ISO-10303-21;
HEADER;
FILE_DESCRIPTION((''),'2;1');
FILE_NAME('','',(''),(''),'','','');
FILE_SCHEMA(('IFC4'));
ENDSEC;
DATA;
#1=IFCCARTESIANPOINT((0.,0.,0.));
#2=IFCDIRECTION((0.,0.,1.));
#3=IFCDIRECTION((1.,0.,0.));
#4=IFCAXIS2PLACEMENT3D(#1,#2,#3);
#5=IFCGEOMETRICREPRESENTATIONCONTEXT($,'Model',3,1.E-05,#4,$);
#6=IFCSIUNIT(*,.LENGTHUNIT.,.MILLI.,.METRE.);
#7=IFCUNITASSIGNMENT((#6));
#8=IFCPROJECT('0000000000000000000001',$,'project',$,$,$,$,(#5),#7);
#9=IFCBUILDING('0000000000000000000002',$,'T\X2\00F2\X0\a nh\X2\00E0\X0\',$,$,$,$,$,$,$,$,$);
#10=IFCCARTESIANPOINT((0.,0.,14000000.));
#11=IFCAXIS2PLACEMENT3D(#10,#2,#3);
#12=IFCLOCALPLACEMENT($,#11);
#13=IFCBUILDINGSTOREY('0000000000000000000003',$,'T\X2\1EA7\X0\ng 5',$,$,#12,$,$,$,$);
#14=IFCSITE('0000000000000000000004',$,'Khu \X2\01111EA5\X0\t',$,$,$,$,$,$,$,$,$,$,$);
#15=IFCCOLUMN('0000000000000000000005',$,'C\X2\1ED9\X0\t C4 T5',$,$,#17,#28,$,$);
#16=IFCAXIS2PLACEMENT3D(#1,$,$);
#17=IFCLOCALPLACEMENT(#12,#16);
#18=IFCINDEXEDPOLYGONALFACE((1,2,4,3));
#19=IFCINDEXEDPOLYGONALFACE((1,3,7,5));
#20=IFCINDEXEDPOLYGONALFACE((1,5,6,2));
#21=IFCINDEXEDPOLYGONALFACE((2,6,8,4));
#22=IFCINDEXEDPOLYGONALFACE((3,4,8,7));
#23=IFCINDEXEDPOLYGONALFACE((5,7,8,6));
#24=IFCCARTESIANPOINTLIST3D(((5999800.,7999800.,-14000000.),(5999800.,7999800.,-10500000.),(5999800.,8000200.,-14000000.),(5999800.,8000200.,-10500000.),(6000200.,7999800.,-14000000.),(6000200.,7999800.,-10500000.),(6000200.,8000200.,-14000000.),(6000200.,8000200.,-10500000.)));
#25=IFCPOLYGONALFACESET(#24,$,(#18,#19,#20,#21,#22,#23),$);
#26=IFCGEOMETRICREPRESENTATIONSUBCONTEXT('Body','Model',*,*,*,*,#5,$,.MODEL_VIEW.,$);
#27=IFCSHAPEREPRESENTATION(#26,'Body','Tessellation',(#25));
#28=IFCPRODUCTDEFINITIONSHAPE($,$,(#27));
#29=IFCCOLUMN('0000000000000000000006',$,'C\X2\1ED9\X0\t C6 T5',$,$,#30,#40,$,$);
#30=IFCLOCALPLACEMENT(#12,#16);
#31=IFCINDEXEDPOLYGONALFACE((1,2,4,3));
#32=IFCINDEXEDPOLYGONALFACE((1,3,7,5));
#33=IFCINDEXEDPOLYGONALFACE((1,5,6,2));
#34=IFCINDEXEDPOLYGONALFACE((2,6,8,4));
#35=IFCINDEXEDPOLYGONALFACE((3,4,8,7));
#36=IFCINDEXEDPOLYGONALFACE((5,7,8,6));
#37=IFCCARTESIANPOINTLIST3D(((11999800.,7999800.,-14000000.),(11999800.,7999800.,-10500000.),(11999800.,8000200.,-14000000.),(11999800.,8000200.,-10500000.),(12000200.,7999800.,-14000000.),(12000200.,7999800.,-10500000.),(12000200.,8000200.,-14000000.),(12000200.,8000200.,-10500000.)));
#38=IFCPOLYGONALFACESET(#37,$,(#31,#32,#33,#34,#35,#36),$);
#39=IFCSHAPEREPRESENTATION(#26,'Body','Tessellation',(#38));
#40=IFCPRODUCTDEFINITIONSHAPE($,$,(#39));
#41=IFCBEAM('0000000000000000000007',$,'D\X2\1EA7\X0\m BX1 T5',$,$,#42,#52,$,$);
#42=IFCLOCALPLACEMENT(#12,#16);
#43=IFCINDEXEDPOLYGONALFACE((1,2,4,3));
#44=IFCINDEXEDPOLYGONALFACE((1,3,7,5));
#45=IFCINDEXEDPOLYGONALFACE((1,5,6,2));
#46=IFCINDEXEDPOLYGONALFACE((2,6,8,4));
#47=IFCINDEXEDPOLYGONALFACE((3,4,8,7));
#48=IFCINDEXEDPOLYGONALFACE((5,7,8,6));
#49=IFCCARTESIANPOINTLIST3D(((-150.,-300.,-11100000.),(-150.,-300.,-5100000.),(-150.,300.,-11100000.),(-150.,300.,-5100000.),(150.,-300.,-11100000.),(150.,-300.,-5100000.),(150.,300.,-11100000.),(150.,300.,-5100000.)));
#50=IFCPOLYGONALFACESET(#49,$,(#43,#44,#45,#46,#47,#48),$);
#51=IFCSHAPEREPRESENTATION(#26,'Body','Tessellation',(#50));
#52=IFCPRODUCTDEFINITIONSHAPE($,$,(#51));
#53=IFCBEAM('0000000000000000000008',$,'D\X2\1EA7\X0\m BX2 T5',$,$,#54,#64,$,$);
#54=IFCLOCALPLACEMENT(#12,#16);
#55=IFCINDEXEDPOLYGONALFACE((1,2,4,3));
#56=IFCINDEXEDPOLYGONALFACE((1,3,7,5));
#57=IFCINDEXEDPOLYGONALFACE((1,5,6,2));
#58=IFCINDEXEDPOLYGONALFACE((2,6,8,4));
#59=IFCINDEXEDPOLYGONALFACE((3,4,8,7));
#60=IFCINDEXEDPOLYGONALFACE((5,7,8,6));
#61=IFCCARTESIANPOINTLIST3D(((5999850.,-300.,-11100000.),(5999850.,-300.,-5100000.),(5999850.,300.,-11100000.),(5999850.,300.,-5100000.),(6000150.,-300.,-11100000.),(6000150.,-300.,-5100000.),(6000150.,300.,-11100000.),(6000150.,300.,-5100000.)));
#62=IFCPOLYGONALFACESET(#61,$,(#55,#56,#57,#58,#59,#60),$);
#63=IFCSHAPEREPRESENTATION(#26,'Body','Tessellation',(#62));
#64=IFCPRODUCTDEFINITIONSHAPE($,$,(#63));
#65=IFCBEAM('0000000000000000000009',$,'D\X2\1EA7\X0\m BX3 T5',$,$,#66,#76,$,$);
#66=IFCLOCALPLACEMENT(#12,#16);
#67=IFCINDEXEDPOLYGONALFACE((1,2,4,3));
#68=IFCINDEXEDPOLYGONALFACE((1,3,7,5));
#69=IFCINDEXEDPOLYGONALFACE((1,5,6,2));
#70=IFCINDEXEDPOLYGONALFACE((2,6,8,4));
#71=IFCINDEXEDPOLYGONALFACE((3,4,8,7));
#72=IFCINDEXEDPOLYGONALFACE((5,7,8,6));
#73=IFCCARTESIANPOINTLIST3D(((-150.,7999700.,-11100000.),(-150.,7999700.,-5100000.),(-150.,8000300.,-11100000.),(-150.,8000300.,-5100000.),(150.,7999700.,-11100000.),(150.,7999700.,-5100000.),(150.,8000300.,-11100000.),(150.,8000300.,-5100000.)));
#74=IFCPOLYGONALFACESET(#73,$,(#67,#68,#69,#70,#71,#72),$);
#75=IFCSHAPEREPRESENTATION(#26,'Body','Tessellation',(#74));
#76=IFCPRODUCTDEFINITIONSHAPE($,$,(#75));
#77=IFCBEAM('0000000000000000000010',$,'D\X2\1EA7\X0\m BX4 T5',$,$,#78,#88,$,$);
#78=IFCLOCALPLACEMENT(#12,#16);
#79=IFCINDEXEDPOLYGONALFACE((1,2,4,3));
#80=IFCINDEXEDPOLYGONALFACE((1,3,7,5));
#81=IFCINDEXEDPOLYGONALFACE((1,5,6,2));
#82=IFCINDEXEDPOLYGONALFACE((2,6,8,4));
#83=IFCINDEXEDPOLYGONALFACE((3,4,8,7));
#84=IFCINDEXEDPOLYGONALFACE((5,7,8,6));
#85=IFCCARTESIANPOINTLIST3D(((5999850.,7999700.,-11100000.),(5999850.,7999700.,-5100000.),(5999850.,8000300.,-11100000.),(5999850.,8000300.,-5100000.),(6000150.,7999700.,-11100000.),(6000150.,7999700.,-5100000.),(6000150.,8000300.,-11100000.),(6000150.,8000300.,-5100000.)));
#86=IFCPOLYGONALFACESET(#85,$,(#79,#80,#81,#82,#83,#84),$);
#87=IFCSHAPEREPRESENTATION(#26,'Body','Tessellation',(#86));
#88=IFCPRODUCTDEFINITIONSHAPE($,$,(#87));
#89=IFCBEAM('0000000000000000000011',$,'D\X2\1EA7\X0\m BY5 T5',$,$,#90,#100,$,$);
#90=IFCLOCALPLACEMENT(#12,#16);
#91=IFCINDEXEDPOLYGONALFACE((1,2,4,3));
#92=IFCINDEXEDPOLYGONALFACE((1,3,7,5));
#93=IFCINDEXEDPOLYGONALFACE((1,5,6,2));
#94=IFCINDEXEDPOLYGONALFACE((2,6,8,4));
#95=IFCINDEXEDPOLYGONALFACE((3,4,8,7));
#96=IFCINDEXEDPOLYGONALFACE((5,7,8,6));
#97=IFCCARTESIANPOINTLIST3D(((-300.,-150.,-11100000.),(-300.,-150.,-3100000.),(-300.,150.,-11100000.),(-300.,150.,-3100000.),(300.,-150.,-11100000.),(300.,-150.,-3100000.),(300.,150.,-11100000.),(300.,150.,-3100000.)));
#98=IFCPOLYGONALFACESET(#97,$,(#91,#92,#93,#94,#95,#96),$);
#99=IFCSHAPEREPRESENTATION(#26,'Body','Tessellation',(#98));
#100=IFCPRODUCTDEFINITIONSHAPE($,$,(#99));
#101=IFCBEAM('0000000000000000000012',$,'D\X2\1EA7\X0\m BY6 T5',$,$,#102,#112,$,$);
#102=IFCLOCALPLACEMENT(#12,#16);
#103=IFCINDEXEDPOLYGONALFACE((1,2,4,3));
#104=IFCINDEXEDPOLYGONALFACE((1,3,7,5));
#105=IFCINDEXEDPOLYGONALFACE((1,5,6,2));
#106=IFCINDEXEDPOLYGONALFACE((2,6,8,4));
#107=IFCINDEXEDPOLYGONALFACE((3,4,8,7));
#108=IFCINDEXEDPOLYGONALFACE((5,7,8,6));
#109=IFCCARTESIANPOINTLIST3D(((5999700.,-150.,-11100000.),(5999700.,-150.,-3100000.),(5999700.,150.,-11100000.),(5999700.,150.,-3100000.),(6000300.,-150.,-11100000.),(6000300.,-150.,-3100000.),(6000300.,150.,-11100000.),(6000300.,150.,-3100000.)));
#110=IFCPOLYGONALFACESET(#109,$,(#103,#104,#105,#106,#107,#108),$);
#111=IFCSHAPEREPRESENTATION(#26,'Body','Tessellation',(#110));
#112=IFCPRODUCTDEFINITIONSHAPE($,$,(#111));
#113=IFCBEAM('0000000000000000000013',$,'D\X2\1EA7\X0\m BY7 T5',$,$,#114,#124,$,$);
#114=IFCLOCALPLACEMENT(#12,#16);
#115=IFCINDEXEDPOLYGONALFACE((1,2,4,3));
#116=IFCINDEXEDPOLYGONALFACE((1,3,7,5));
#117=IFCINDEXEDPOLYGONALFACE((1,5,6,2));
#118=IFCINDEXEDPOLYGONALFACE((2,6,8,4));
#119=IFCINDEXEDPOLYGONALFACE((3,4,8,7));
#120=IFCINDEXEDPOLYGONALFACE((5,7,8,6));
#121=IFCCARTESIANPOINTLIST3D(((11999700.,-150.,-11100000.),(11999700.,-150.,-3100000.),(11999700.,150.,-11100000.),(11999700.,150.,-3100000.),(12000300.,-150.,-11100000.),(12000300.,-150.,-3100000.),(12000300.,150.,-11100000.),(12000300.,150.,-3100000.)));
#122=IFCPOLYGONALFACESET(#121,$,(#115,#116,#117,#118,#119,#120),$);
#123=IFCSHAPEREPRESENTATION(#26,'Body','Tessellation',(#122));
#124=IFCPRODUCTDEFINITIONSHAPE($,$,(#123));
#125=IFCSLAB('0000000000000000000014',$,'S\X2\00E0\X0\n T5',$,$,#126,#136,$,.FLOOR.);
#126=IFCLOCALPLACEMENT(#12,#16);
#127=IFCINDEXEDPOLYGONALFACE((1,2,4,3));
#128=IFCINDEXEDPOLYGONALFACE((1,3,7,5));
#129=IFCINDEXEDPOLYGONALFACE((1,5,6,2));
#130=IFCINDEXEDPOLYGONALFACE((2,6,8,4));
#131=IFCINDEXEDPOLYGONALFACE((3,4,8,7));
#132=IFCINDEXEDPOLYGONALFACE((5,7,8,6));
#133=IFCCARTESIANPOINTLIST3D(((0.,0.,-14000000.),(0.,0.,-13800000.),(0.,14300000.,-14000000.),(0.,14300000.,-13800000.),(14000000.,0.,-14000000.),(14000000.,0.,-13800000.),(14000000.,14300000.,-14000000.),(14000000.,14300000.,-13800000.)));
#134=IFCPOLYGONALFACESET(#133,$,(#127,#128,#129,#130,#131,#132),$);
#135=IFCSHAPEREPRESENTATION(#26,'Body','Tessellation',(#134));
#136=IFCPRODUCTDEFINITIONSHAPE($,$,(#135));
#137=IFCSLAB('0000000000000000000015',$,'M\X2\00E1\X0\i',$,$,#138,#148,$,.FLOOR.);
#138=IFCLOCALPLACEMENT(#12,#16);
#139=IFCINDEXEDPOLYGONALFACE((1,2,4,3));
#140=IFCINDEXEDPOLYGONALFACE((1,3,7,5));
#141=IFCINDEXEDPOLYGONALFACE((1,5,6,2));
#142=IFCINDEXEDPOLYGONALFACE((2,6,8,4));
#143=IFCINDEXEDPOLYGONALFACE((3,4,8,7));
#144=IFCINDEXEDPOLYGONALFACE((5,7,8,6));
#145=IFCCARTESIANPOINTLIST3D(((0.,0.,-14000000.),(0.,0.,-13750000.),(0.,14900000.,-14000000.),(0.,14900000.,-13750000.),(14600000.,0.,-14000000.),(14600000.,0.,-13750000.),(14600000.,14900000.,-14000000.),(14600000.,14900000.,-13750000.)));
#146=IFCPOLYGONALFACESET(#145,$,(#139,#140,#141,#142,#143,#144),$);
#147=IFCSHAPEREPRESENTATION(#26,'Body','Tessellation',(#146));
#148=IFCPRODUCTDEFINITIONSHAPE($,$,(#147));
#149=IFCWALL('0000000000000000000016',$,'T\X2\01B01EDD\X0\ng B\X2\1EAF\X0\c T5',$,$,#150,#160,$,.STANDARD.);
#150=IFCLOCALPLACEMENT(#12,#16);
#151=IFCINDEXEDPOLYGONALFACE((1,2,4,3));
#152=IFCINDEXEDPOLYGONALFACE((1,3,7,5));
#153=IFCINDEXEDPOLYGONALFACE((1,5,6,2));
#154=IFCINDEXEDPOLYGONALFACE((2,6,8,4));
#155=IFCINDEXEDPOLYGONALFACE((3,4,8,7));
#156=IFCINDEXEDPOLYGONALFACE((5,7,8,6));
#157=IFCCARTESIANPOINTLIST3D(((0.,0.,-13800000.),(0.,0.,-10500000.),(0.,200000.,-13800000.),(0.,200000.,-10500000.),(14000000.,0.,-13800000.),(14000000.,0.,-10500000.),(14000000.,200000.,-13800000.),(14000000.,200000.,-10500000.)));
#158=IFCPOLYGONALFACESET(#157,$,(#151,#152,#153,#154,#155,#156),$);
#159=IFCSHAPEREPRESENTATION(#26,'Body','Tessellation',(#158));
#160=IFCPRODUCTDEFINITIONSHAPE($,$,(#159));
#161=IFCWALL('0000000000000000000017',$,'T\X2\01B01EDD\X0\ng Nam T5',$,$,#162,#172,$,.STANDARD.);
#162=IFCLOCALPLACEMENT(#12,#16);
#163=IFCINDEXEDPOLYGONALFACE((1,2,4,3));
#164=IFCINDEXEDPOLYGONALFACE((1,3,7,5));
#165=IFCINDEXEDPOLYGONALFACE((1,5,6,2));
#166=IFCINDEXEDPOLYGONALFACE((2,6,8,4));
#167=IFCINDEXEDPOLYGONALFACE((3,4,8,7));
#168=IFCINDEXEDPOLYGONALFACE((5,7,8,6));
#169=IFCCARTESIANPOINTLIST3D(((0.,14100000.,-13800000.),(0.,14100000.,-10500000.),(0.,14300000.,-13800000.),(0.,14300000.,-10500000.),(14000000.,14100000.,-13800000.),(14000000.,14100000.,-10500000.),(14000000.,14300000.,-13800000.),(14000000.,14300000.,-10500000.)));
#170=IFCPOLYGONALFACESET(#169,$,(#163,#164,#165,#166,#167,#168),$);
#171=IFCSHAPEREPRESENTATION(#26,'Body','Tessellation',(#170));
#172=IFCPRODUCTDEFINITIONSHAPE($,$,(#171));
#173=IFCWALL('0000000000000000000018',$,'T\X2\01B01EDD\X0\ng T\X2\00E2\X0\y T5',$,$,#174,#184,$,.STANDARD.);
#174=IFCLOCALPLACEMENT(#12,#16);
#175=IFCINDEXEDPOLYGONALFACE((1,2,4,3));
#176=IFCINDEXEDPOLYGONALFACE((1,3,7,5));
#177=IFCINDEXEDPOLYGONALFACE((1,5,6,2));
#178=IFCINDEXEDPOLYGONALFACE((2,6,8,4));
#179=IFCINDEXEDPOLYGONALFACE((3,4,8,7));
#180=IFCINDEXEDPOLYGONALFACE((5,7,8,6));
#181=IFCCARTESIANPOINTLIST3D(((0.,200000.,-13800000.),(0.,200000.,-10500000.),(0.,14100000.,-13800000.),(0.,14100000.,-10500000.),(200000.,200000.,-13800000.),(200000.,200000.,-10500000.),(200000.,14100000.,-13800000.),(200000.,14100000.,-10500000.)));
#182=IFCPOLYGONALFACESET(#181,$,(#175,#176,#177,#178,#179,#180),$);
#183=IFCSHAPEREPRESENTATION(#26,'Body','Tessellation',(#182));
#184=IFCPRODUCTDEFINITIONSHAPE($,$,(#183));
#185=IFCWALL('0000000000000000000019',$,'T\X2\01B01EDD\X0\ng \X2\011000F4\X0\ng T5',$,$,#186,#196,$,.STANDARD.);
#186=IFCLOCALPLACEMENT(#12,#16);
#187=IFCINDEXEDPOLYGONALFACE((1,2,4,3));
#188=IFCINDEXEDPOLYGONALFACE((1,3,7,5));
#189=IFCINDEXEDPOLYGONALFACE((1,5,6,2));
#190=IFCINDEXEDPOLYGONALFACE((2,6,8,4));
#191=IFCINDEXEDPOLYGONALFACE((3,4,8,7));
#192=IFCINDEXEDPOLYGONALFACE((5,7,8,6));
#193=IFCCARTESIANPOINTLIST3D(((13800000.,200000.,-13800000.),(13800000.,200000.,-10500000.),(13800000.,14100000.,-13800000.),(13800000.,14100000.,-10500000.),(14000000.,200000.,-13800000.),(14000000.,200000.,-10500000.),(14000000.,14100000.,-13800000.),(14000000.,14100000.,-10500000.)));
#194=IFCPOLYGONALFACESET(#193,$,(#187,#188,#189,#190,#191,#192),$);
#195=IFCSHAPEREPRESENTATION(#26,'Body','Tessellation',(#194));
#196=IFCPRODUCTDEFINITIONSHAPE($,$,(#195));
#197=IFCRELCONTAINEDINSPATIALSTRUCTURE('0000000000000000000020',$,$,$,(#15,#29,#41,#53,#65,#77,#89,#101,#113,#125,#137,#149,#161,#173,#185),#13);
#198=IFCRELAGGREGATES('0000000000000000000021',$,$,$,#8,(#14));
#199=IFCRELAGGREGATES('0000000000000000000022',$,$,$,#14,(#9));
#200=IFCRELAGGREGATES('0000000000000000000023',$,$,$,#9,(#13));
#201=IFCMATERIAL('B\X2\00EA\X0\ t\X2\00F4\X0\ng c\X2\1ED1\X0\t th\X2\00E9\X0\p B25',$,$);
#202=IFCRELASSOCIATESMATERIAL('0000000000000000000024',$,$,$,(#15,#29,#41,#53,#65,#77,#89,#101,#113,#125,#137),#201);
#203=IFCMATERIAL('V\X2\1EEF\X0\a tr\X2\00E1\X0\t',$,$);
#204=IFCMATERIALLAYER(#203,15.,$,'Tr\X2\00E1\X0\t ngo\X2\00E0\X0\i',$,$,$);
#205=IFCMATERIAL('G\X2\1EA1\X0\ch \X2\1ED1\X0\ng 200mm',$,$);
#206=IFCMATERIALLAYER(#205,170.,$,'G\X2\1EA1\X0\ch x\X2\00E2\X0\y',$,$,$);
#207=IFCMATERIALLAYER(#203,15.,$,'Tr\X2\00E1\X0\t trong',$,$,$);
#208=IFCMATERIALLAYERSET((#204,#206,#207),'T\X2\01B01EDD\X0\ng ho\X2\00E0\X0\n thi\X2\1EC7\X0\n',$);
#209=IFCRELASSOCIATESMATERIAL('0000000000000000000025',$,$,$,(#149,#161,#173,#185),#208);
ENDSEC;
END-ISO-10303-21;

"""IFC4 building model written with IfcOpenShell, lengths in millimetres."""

from ifc_helpers import new_model, entity, si_unit, frame, origin_with_axes, place, context, subcontext, project, spatial, indexed_curve, outline, extrude, material, layer, layer_set, layer_usage, element, save


model = new_model("IFC4")

# Units and contexts
model_context = context("Model", 3, precision=1e-05, world=origin_with_axes())
body_context = subcontext(model_context, "Body", "Model", "MODEL_VIEW")
ifc_project = project(units=[si_unit("LENGTHUNIT", "METRE", prefix="MILLI")], contexts=[model_context])

# Site, building, storey
site = spatial("IfcSite", under=ifc_project, Name="Khu đất")
building = spatial("IfcBuilding", under=site, Name="Tòa nhà")
storey_placement = place(None, frame((0.0, 0.0, 14000000.0), z_axis=(0.0, 0.0, 1.0), x_axis=(1.0, 0.0, 0.0)))
storey = spatial("IfcBuildingStorey", under=building, at=storey_placement, Name="Tầng 5")

# Columns
ifc_material_1 = material(Name="Bê tông cốt thép B25")
for number, where, z_axis, x_axis, name in (
    (1, (6000000.0, 8000000.0, -14000000.0), (0.0, 0.0, 1.0), (1.0, 0.0, 0.0), "Cột C4 T5"),
    (2, (12000000.0, 8000000.0, -14000000.0), (0.0, 0.0, 1.0), (1.0, 0.0, 0.0), "Cột C6 T5"),
):
    element("IfcColumn", number, at=place(storey_placement, frame(where, z_axis=z_axis, x_axis=x_axis)), inside=storey, material=ifc_material_1, Name=name, context=body_context, shape_type="SweptSolid", body=[
        extrude(entity("IfcRectangleProfileDef", None, None, None, 400.0, 400.0), origin_with_axes(), (0.0, 0.0, 1.0), 3500000.0),
    ])

# Beams
for number, where, z_axis, x_axis, name in (
    (3, (0.0, 0.0, -11100000.0), (0.0, 0.0, 1.0), (1.0, 0.0, 0.0), "Dầm BX1 T5"),
    (4, (6000000.0, 0.0, -11100000.0), (0.0, 0.0, 1.0), (1.0, 0.0, 0.0), "Dầm BX2 T5"),
    (5, (0.0, 8000000.0, -11100000.0), (0.0, 0.0, 1.0), (1.0, 0.0, 0.0), "Dầm BX3 T5"),
    (6, (6000000.0, 8000000.0, -11100000.0), (0.0, 0.0, 1.0), (1.0, 0.0, 0.0), "Dầm BX4 T5"),
):
    element("IfcBeam", number, at=place(storey_placement, frame(where, z_axis=z_axis, x_axis=x_axis)), inside=storey, material=ifc_material_1, Name=name, context=body_context, shape_type="SweptSolid", body=[
        extrude(entity("IfcRectangleProfileDef", None, None, None, 300.0, 600.0), origin_with_axes(), (0.0, 0.0, 1.0), 6000000.0),
    ])
for number, where, z_axis, x_axis, name in (
    (7, (0.0, 0.0, -11100000.0), (0.0, 0.0, 1.0), (0.0, 1.0, 0.0), "Dầm BY5 T5"),
    (8, (6000000.0, 0.0, -11100000.0), (0.0, 0.0, 1.0), (0.0, 1.0, 0.0), "Dầm BY6 T5"),
    (9, (12000000.0, 0.0, -11100000.0), (0.0, 0.0, 1.0), (0.0, 1.0, 0.0), "Dầm BY7 T5"),
):
    element("IfcBeam", number, at=place(storey_placement, frame(where, z_axis=z_axis, x_axis=x_axis)), inside=storey, material=ifc_material_1, Name=name, context=body_context, shape_type="SweptSolid", body=[
        extrude(entity("IfcRectangleProfileDef", None, None, None, 300.0, 600.0), origin_with_axes(), (0.0, 0.0, 1.0), 8000000.0),
    ])

# Slabs
slab_1_placement = place(storey_placement, frame((0.0, 0.0, -14000000.0), z_axis=(0.0, 0.0, 1.0), x_axis=(1.0, 0.0, 0.0)))
element("IfcSlab", 10, at=slab_1_placement, inside=storey, material=ifc_material_1, Name="Sàn T5", PredefinedType="FLOOR", context=body_context, shape_type="SweptSolid", body=[
    extrude(outline(indexed_curve([(0.0, 0.0), (14000000.0, 0.0), (14000000.0, 14300000.0), (0.0, 14300000.0), (0.0, 0.0)])), None, (0.0, 0.0, 1.0), 200000.0),
])
slab_2_placement = place(storey_placement, frame((0.0, 0.0, -14000000.0), z_axis=(0.0, 0.0, 1.0), x_axis=(1.0, 0.0, 0.0)))
element("IfcSlab", 11, at=slab_2_placement, inside=storey, material=ifc_material_1, Name="Mái", PredefinedType="FLOOR", context=body_context, shape_type="SweptSolid", body=[
    extrude(outline(indexed_curve([(0.0, 0.0), (14600000.0, 0.0), (14600000.0, 14900000.0), (0.0, 14900000.0), (0.0, 0.0)])), None, (0.0, 0.0, 1.0), 250000.0),
])

# Walls
ifc_material_2 = material(Name="Vữa trát")
ifc_layer_1 = layer(ifc_material_2, 15.0, Name="Trát ngoài")
ifc_material_3 = material(Name="Gạch ống 200mm")
ifc_layer_2 = layer(ifc_material_3, 170.0, Name="Gạch xây")
ifc_layer_3 = layer(ifc_material_2, 15.0, Name="Trát trong")
ifc_layer_set = layer_set([ifc_layer_1, ifc_layer_2, ifc_layer_3], Name="Tường hoàn thiện")
ifc_layer_usage_1 = layer_usage(ifc_layer_set, "AXIS2", "POSITIVE", 0.0)
wall_1_placement = place(storey_placement, frame((0.0, 0.0, -13800000.0), z_axis=(0.0, 0.0, 1.0), x_axis=(1.0, 0.0, 0.0)))
element("IfcWall", 12, at=wall_1_placement, inside=storey, material=ifc_layer_usage_1, Name="Tường Bắc T5", PredefinedType="STANDARD", context=body_context, shape_type="SweptSolid", body=[
    extrude(outline(indexed_curve([(0.0, 0.0), (0.0, 200000.0), (14000000.0, 200000.0), (14000000.0, 0.0), (0.0, 0.0)], self_intersect=False)), origin_with_axes(), (0.0, 0.0, 1.0), 3300000.0),
])
ifc_layer_usage_2 = layer_usage(ifc_layer_set, "AXIS2", "POSITIVE", 0.0)
wall_2_placement = place(storey_placement, frame((0.0, 14100000.0, -13800000.0), z_axis=(0.0, 0.0, 1.0), x_axis=(1.0, 0.0, 0.0)))
element("IfcWall", 13, at=wall_2_placement, inside=storey, material=ifc_layer_usage_2, Name="Tường Nam T5", PredefinedType="STANDARD", context=body_context, shape_type="SweptSolid", body=[
    extrude(outline(indexed_curve([(0.0, 0.0), (0.0, 200000.0), (14000000.0, 200000.0), (14000000.0, 0.0), (0.0, 0.0)], self_intersect=False)), origin_with_axes(), (0.0, 0.0, 1.0), 3300000.0),
])
ifc_layer_usage_3 = layer_usage(ifc_layer_set, "AXIS2", "POSITIVE", 0.0)
wall_3_placement = place(storey_placement, frame((0.0, 200000.0, -13800000.0), z_axis=(0.0, 0.0, 1.0), x_axis=(1.0, 0.0, 0.0)))
element("IfcWall", 14, at=wall_3_placement, inside=storey, material=ifc_layer_usage_3, Name="Tường Tây T5", PredefinedType="STANDARD", context=body_context, shape_type="SweptSolid", body=[
    extrude(outline(indexed_curve([(0.0, 0.0), (0.0, 13900000.0), (200000.0, 13900000.0), (200000.0, 0.0), (0.0, 0.0)], self_intersect=False)), origin_with_axes(), (0.0, 0.0, 1.0), 3300000.0),
])
ifc_layer_usage_4 = layer_usage(ifc_layer_set, "AXIS2", "POSITIVE", 0.0)
wall_4_placement = place(storey_placement, frame((13800000.0, 200000.0, -13800000.0), z_axis=(0.0, 0.0, 1.0), x_axis=(1.0, 0.0, 0.0)))
element("IfcWall", 15, at=wall_4_placement, inside=storey, material=ifc_layer_usage_4, Name="Tường Đông T5", PredefinedType="STANDARD", context=body_context, shape_type="SweptSolid", body=[
    extrude(outline(indexed_curve([(0.0, 0.0), (0.0, 13900000.0), (200000.0, 13900000.0), (200000.0, 0.0), (0.0, 0.0)], self_intersect=False)), origin_with_axes(), (0.0, 0.0, 1.0), 3300000.0),
])

save(model, "model.ifc")
